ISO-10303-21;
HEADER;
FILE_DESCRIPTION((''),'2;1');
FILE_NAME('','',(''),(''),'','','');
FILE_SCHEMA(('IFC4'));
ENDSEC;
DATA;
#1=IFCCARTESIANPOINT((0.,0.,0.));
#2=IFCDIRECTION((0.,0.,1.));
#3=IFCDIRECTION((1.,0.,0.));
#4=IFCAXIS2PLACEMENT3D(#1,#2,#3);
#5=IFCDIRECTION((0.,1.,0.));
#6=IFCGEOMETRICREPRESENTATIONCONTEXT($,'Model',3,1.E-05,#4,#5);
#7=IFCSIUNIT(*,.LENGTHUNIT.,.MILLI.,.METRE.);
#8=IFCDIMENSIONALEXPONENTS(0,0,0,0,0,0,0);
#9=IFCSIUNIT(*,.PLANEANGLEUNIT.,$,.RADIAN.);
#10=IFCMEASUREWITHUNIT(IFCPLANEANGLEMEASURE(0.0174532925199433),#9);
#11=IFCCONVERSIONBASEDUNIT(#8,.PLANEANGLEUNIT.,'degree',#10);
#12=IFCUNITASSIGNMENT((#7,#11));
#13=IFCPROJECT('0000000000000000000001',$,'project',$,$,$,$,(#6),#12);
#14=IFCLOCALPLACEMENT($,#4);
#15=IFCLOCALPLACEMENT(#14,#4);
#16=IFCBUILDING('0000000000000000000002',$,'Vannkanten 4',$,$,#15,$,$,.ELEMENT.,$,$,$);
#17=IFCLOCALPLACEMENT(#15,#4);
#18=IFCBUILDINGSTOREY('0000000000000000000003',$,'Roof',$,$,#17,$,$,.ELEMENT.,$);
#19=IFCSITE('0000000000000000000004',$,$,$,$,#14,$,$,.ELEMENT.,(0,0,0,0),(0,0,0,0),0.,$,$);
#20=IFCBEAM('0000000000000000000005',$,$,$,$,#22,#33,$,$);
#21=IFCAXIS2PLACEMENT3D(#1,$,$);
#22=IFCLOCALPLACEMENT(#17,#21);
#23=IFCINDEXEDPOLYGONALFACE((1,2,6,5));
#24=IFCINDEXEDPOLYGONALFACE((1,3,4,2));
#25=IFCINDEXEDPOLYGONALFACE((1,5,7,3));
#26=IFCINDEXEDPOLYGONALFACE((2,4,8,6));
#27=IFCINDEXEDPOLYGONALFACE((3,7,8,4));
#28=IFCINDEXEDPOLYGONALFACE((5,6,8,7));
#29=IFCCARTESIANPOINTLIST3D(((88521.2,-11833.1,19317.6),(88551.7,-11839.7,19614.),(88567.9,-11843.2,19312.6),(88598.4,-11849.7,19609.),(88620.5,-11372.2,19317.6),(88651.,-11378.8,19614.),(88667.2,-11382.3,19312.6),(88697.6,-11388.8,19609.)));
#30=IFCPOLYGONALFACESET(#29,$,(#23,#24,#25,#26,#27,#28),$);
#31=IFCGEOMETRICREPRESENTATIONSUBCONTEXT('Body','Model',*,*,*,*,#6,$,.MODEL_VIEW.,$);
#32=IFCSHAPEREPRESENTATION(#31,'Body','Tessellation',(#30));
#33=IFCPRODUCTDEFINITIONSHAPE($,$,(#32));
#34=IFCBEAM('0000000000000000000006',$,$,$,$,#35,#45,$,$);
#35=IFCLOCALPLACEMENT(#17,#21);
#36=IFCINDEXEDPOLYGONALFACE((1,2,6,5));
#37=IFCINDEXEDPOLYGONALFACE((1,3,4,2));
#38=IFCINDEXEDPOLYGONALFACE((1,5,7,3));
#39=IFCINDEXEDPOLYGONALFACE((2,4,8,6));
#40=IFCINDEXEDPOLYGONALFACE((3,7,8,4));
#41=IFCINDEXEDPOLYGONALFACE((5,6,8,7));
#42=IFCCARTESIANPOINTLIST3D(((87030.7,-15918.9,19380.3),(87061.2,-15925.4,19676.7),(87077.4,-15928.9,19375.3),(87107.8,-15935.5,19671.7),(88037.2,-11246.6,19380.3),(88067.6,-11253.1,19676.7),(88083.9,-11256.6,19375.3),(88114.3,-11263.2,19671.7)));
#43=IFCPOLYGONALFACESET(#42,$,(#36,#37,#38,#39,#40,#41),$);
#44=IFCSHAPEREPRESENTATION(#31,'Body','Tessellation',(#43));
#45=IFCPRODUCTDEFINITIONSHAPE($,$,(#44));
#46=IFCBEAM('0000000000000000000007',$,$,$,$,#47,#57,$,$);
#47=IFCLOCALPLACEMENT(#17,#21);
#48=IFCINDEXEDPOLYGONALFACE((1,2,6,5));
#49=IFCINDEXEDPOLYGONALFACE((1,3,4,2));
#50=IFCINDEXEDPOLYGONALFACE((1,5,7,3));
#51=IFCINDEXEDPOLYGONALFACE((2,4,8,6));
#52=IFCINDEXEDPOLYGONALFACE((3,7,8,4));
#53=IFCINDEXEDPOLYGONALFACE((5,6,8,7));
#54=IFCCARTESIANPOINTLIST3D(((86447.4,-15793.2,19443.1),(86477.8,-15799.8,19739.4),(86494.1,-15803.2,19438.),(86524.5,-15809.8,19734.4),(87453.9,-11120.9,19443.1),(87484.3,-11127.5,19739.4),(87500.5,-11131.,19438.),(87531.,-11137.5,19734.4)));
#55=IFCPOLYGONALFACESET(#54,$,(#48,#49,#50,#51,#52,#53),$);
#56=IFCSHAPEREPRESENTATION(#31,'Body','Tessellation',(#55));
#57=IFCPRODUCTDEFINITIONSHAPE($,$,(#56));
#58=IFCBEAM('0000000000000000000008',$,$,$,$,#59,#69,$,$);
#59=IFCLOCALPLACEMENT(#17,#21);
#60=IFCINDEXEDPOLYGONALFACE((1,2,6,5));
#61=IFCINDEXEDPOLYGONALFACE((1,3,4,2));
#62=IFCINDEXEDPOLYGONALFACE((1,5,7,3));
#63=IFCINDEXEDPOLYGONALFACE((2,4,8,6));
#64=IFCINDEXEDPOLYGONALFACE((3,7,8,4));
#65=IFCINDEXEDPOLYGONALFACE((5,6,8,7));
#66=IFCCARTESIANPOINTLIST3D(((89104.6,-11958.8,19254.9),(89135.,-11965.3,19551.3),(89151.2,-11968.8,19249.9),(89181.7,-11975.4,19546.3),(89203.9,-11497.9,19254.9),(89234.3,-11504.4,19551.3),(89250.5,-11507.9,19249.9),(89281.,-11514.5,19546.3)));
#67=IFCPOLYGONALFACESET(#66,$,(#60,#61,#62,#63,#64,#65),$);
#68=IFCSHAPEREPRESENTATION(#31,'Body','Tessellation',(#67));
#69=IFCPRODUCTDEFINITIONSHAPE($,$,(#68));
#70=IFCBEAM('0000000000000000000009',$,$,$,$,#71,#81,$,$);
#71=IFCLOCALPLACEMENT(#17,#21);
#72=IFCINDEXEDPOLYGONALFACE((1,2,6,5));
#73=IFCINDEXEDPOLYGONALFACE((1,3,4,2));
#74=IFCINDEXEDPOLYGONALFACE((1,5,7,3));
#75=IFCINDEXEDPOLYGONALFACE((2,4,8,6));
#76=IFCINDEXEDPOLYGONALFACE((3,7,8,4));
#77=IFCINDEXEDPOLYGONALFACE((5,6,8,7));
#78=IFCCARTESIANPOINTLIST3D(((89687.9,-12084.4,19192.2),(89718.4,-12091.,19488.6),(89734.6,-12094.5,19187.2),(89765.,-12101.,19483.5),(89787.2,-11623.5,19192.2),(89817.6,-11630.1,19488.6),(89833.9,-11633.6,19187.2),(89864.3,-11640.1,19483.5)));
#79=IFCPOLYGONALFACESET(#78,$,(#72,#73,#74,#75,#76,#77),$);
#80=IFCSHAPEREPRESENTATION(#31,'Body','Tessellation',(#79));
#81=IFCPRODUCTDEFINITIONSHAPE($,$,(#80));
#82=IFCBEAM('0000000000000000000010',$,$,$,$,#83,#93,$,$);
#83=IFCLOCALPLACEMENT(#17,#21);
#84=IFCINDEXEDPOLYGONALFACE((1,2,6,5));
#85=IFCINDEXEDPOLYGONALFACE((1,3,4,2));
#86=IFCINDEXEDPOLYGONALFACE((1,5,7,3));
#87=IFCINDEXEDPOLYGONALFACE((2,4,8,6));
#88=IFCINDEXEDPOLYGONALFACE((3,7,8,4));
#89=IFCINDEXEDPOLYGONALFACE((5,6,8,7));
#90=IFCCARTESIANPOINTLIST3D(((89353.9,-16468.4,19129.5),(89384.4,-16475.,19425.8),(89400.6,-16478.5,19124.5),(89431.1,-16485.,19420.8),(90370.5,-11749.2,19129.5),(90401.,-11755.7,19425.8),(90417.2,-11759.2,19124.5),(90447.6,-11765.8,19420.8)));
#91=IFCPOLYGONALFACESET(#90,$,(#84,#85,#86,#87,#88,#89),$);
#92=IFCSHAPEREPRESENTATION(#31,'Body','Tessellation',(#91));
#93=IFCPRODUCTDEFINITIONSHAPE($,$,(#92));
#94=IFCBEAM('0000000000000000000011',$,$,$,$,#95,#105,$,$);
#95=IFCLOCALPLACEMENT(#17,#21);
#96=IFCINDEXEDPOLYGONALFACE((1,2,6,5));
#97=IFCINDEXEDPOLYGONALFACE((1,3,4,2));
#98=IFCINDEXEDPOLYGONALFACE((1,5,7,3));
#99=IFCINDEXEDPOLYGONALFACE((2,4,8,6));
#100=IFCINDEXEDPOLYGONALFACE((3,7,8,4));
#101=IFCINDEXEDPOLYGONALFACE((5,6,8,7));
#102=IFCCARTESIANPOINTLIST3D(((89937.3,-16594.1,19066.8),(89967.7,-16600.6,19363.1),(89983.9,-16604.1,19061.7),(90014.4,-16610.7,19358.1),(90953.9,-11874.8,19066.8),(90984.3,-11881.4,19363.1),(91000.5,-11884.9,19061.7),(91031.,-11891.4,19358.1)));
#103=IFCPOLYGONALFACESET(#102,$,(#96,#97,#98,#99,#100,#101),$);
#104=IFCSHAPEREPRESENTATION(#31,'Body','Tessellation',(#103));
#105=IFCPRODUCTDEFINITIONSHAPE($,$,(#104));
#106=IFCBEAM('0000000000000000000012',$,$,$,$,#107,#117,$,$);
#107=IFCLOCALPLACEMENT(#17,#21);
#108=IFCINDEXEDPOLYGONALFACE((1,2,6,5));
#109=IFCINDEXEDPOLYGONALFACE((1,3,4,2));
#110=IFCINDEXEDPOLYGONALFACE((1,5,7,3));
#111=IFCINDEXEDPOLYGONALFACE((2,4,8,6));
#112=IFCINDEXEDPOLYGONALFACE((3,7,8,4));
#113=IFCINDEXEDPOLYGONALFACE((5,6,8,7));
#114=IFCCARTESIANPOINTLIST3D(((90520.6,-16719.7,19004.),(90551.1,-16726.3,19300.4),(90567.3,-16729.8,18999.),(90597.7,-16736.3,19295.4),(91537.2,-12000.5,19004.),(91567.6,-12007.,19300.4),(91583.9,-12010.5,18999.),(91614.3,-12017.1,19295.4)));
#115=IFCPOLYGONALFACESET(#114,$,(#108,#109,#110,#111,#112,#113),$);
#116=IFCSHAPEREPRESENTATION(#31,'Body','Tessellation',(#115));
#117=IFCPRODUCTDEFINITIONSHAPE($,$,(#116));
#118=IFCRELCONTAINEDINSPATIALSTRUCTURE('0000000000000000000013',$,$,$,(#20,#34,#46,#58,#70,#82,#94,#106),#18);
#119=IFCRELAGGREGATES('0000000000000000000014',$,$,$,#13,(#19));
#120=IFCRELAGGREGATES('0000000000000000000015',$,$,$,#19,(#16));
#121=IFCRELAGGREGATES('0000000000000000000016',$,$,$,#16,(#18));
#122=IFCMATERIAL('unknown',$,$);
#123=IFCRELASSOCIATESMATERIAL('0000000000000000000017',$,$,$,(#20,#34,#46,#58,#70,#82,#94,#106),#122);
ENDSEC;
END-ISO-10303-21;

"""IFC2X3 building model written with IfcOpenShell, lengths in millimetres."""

from ifc_helpers import new_model, entity, si_unit, converted_unit, direction, frame, origin_with_axes, place, context, subcontext, project, spatial, polyline, segment, composite_curve, outline, extrude, material, element, save


model = new_model("IFC2X3")

# Units and contexts
model_context = context("Model", 3, precision=1e-05, world=origin_with_axes(), true_north=direction((0.0, 1.0, 0.0)))
body_context = subcontext(model_context, "Body", "Model", "MODEL_VIEW")
ifc_project = project(units=[si_unit("LENGTHUNIT", "METRE", prefix="MILLI"), converted_unit("PLANEANGLEUNIT", "degree", entity("IfcPlaneAngleMeasure", 0.0174532925199433), si_unit("PLANEANGLEUNIT", "RADIAN"), dimensions=[0, 0, 0, 0, 0, 0, 0])], contexts=[model_context])

# Site, building, storey
site_placement = place(None, origin_with_axes())
site = spatial("IfcSite", under=ifc_project, at=site_placement, CompositionType="ELEMENT", RefLatitude=(0, 0, 0, 0), RefLongitude=(0, 0, 0, 0), RefElevation=0.0)
building_placement = place(site_placement, origin_with_axes())
building = spatial("IfcBuilding", under=site, at=building_placement, Name="Vannkanten 4", CompositionType="ELEMENT")
storey_placement = place(building_placement, origin_with_axes())
storey = spatial("IfcBuildingStorey", under=building, at=storey_placement, Name="Roof", CompositionType="ELEMENT")

# Shared definitions
ifc_material = material(Name="unknown")

# Beams
beam_1_placement = place(storey_placement, frame((88559.8, -11841.4, 19463.3), z_axis=(0.210582, 0.977576, 0.0), x_axis=(-0.972221, 0.209428, 0.104528)))
element("IfcBeam", 1, at=beam_1_placement, inside=storey, material=ifc_material, context=body_context, shape_type="SweptSolid", body=[
    extrude(outline(composite_curve([segment(polyline([(-24.0, -149.0), (-24.0, 149.0), (24.0, 149.0), (24.0, -149.0), (-24.0, -149.0)]), True, "CONTINUOUS")], self_intersect=False)), frame((0.0, 0.0, 0.0), z_axis=(0.0, 0.0, 1.0), x_axis=(1.0, 0.0, 0.0)), (0.0, 0.0, 1.0), 471.5),
])
beam_2_placement = place(storey_placement, frame((87069.3, -15927.2, 19526.0), z_axis=(0.210582, 0.977576, 0.0), x_axis=(-0.972221, 0.209428, 0.104528)))
element("IfcBeam", 2, at=beam_2_placement, inside=storey, material=ifc_material, context=body_context, shape_type="SweptSolid", body=[
    extrude(outline(composite_curve([segment(polyline([(-24.0, -149.0), (-24.0, 149.0), (24.0, 149.0), (24.0, -149.0), (-24.0, -149.0)]), True, "CONTINUOUS")], self_intersect=False)), frame((0.0, 0.0, 0.0), z_axis=(0.0, 0.0, 1.0), x_axis=(1.0, 0.0, 0.0)), (0.0, 0.0, 1.0), 4779.4),
])
beam_3_placement = place(storey_placement, frame((86486.0, -15801.5, 19588.7), z_axis=(0.210582, 0.977576, 0.0), x_axis=(-0.972221, 0.209428, 0.104528)))
element("IfcBeam", 3, at=beam_3_placement, inside=storey, material=ifc_material, context=body_context, shape_type="SweptSolid", body=[
    extrude(outline(composite_curve([segment(polyline([(-24.0, -149.0), (-24.0, 149.0), (24.0, 149.0), (24.0, -149.0), (-24.0, -149.0)]), True, "CONTINUOUS")], self_intersect=False)), frame((0.0, 0.0, 0.0), z_axis=(0.0, 0.0, 1.0), x_axis=(1.0, 0.0, 0.0)), (0.0, 0.0, 1.0), 4779.4),
])
beam_4_placement = place(storey_placement, frame((89143.1, -11967.1, 19400.6), z_axis=(0.210582, 0.977576, 0.0), x_axis=(-0.972221, 0.209428, 0.104528)))
element("IfcBeam", 4, at=beam_4_placement, inside=storey, material=ifc_material, context=body_context, shape_type="SweptSolid", body=[
    extrude(outline(composite_curve([segment(polyline([(-24.0, -149.0), (-24.0, 149.0), (24.0, 149.0), (24.0, -149.0), (-24.0, -149.0)]), True, "CONTINUOUS")], self_intersect=False)), frame((0.0, 0.0, 0.0), z_axis=(0.0, 0.0, 1.0), x_axis=(1.0, 0.0, 0.0)), (0.0, 0.0, 1.0), 471.5),
])
beam_5_placement = place(storey_placement, frame((89726.5, -12092.7, 19337.9), z_axis=(0.210582, 0.977576, 0.0), x_axis=(-0.972221, 0.209428, 0.104528)))
element("IfcBeam", 5, at=beam_5_placement, inside=storey, material=ifc_material, context=body_context, shape_type="SweptSolid", body=[
    extrude(outline(composite_curve([segment(polyline([(-24.0, -149.0), (-24.0, 149.0), (24.0, 149.0), (24.0, -149.0), (-24.0, -149.0)]), True, "CONTINUOUS")], self_intersect=False)), frame((0.0, 0.0, 0.0), z_axis=(0.0, 0.0, 1.0), x_axis=(1.0, 0.0, 0.0)), (0.0, 0.0, 1.0), 471.5),
])
beam_6_placement = place(storey_placement, frame((89392.5, -16476.7, 19275.1), z_axis=(0.210582, 0.977576, 0.0), x_axis=(-0.972221, 0.209428, 0.104528)))
element("IfcBeam", 6, at=beam_6_placement, inside=storey, material=ifc_material, context=body_context, shape_type="SweptSolid", body=[
    extrude(outline(composite_curve([segment(polyline([(-24.0, -149.0), (-24.0, 149.0), (24.0, 149.0), (24.0, -149.0), (-24.0, -149.0)]), True, "CONTINUOUS")], self_intersect=False)), frame((0.0, 0.0, 0.0), z_axis=(0.0, 0.0, 1.0), x_axis=(1.0, 0.0, 0.0)), (0.0, 0.0, 1.0), 4827.5),
])
beam_7_placement = place(storey_placement, frame((89975.8, -16602.4, 19212.4), z_axis=(0.210582, 0.977576, 0.0), x_axis=(-0.972221, 0.209428, 0.104528)))
element("IfcBeam", 7, at=beam_7_placement, inside=storey, material=ifc_material, context=body_context, shape_type="SweptSolid", body=[
    extrude(outline(composite_curve([segment(polyline([(-24.0, -149.0), (-24.0, 149.0), (24.0, 149.0), (24.0, -149.0), (-24.0, -149.0)]), True, "CONTINUOUS")], self_intersect=False)), frame((0.0, 0.0, 0.0), z_axis=(0.0, 0.0, 1.0), x_axis=(1.0, 0.0, 0.0)), (0.0, 0.0, 1.0), 4827.5),
])
beam_8_placement = place(storey_placement, frame((90559.2, -16728.0, 19149.7), z_axis=(0.210582, 0.977576, 0.0), x_axis=(-0.972221, 0.209428, 0.104528)))
element("IfcBeam", 8, at=beam_8_placement, inside=storey, material=ifc_material, context=body_context, shape_type="SweptSolid", body=[
    extrude(outline(composite_curve([segment(polyline([(-24.0, -149.0), (-24.0, 149.0), (24.0, 149.0), (24.0, -149.0), (-24.0, -149.0)]), True, "CONTINUOUS")], self_intersect=False)), frame((0.0, 0.0, 0.0), z_axis=(0.0, 0.0, 1.0), x_axis=(1.0, 0.0, 0.0)), (0.0, 0.0, 1.0), 4827.5),
])

save(model, "model.ifc")
